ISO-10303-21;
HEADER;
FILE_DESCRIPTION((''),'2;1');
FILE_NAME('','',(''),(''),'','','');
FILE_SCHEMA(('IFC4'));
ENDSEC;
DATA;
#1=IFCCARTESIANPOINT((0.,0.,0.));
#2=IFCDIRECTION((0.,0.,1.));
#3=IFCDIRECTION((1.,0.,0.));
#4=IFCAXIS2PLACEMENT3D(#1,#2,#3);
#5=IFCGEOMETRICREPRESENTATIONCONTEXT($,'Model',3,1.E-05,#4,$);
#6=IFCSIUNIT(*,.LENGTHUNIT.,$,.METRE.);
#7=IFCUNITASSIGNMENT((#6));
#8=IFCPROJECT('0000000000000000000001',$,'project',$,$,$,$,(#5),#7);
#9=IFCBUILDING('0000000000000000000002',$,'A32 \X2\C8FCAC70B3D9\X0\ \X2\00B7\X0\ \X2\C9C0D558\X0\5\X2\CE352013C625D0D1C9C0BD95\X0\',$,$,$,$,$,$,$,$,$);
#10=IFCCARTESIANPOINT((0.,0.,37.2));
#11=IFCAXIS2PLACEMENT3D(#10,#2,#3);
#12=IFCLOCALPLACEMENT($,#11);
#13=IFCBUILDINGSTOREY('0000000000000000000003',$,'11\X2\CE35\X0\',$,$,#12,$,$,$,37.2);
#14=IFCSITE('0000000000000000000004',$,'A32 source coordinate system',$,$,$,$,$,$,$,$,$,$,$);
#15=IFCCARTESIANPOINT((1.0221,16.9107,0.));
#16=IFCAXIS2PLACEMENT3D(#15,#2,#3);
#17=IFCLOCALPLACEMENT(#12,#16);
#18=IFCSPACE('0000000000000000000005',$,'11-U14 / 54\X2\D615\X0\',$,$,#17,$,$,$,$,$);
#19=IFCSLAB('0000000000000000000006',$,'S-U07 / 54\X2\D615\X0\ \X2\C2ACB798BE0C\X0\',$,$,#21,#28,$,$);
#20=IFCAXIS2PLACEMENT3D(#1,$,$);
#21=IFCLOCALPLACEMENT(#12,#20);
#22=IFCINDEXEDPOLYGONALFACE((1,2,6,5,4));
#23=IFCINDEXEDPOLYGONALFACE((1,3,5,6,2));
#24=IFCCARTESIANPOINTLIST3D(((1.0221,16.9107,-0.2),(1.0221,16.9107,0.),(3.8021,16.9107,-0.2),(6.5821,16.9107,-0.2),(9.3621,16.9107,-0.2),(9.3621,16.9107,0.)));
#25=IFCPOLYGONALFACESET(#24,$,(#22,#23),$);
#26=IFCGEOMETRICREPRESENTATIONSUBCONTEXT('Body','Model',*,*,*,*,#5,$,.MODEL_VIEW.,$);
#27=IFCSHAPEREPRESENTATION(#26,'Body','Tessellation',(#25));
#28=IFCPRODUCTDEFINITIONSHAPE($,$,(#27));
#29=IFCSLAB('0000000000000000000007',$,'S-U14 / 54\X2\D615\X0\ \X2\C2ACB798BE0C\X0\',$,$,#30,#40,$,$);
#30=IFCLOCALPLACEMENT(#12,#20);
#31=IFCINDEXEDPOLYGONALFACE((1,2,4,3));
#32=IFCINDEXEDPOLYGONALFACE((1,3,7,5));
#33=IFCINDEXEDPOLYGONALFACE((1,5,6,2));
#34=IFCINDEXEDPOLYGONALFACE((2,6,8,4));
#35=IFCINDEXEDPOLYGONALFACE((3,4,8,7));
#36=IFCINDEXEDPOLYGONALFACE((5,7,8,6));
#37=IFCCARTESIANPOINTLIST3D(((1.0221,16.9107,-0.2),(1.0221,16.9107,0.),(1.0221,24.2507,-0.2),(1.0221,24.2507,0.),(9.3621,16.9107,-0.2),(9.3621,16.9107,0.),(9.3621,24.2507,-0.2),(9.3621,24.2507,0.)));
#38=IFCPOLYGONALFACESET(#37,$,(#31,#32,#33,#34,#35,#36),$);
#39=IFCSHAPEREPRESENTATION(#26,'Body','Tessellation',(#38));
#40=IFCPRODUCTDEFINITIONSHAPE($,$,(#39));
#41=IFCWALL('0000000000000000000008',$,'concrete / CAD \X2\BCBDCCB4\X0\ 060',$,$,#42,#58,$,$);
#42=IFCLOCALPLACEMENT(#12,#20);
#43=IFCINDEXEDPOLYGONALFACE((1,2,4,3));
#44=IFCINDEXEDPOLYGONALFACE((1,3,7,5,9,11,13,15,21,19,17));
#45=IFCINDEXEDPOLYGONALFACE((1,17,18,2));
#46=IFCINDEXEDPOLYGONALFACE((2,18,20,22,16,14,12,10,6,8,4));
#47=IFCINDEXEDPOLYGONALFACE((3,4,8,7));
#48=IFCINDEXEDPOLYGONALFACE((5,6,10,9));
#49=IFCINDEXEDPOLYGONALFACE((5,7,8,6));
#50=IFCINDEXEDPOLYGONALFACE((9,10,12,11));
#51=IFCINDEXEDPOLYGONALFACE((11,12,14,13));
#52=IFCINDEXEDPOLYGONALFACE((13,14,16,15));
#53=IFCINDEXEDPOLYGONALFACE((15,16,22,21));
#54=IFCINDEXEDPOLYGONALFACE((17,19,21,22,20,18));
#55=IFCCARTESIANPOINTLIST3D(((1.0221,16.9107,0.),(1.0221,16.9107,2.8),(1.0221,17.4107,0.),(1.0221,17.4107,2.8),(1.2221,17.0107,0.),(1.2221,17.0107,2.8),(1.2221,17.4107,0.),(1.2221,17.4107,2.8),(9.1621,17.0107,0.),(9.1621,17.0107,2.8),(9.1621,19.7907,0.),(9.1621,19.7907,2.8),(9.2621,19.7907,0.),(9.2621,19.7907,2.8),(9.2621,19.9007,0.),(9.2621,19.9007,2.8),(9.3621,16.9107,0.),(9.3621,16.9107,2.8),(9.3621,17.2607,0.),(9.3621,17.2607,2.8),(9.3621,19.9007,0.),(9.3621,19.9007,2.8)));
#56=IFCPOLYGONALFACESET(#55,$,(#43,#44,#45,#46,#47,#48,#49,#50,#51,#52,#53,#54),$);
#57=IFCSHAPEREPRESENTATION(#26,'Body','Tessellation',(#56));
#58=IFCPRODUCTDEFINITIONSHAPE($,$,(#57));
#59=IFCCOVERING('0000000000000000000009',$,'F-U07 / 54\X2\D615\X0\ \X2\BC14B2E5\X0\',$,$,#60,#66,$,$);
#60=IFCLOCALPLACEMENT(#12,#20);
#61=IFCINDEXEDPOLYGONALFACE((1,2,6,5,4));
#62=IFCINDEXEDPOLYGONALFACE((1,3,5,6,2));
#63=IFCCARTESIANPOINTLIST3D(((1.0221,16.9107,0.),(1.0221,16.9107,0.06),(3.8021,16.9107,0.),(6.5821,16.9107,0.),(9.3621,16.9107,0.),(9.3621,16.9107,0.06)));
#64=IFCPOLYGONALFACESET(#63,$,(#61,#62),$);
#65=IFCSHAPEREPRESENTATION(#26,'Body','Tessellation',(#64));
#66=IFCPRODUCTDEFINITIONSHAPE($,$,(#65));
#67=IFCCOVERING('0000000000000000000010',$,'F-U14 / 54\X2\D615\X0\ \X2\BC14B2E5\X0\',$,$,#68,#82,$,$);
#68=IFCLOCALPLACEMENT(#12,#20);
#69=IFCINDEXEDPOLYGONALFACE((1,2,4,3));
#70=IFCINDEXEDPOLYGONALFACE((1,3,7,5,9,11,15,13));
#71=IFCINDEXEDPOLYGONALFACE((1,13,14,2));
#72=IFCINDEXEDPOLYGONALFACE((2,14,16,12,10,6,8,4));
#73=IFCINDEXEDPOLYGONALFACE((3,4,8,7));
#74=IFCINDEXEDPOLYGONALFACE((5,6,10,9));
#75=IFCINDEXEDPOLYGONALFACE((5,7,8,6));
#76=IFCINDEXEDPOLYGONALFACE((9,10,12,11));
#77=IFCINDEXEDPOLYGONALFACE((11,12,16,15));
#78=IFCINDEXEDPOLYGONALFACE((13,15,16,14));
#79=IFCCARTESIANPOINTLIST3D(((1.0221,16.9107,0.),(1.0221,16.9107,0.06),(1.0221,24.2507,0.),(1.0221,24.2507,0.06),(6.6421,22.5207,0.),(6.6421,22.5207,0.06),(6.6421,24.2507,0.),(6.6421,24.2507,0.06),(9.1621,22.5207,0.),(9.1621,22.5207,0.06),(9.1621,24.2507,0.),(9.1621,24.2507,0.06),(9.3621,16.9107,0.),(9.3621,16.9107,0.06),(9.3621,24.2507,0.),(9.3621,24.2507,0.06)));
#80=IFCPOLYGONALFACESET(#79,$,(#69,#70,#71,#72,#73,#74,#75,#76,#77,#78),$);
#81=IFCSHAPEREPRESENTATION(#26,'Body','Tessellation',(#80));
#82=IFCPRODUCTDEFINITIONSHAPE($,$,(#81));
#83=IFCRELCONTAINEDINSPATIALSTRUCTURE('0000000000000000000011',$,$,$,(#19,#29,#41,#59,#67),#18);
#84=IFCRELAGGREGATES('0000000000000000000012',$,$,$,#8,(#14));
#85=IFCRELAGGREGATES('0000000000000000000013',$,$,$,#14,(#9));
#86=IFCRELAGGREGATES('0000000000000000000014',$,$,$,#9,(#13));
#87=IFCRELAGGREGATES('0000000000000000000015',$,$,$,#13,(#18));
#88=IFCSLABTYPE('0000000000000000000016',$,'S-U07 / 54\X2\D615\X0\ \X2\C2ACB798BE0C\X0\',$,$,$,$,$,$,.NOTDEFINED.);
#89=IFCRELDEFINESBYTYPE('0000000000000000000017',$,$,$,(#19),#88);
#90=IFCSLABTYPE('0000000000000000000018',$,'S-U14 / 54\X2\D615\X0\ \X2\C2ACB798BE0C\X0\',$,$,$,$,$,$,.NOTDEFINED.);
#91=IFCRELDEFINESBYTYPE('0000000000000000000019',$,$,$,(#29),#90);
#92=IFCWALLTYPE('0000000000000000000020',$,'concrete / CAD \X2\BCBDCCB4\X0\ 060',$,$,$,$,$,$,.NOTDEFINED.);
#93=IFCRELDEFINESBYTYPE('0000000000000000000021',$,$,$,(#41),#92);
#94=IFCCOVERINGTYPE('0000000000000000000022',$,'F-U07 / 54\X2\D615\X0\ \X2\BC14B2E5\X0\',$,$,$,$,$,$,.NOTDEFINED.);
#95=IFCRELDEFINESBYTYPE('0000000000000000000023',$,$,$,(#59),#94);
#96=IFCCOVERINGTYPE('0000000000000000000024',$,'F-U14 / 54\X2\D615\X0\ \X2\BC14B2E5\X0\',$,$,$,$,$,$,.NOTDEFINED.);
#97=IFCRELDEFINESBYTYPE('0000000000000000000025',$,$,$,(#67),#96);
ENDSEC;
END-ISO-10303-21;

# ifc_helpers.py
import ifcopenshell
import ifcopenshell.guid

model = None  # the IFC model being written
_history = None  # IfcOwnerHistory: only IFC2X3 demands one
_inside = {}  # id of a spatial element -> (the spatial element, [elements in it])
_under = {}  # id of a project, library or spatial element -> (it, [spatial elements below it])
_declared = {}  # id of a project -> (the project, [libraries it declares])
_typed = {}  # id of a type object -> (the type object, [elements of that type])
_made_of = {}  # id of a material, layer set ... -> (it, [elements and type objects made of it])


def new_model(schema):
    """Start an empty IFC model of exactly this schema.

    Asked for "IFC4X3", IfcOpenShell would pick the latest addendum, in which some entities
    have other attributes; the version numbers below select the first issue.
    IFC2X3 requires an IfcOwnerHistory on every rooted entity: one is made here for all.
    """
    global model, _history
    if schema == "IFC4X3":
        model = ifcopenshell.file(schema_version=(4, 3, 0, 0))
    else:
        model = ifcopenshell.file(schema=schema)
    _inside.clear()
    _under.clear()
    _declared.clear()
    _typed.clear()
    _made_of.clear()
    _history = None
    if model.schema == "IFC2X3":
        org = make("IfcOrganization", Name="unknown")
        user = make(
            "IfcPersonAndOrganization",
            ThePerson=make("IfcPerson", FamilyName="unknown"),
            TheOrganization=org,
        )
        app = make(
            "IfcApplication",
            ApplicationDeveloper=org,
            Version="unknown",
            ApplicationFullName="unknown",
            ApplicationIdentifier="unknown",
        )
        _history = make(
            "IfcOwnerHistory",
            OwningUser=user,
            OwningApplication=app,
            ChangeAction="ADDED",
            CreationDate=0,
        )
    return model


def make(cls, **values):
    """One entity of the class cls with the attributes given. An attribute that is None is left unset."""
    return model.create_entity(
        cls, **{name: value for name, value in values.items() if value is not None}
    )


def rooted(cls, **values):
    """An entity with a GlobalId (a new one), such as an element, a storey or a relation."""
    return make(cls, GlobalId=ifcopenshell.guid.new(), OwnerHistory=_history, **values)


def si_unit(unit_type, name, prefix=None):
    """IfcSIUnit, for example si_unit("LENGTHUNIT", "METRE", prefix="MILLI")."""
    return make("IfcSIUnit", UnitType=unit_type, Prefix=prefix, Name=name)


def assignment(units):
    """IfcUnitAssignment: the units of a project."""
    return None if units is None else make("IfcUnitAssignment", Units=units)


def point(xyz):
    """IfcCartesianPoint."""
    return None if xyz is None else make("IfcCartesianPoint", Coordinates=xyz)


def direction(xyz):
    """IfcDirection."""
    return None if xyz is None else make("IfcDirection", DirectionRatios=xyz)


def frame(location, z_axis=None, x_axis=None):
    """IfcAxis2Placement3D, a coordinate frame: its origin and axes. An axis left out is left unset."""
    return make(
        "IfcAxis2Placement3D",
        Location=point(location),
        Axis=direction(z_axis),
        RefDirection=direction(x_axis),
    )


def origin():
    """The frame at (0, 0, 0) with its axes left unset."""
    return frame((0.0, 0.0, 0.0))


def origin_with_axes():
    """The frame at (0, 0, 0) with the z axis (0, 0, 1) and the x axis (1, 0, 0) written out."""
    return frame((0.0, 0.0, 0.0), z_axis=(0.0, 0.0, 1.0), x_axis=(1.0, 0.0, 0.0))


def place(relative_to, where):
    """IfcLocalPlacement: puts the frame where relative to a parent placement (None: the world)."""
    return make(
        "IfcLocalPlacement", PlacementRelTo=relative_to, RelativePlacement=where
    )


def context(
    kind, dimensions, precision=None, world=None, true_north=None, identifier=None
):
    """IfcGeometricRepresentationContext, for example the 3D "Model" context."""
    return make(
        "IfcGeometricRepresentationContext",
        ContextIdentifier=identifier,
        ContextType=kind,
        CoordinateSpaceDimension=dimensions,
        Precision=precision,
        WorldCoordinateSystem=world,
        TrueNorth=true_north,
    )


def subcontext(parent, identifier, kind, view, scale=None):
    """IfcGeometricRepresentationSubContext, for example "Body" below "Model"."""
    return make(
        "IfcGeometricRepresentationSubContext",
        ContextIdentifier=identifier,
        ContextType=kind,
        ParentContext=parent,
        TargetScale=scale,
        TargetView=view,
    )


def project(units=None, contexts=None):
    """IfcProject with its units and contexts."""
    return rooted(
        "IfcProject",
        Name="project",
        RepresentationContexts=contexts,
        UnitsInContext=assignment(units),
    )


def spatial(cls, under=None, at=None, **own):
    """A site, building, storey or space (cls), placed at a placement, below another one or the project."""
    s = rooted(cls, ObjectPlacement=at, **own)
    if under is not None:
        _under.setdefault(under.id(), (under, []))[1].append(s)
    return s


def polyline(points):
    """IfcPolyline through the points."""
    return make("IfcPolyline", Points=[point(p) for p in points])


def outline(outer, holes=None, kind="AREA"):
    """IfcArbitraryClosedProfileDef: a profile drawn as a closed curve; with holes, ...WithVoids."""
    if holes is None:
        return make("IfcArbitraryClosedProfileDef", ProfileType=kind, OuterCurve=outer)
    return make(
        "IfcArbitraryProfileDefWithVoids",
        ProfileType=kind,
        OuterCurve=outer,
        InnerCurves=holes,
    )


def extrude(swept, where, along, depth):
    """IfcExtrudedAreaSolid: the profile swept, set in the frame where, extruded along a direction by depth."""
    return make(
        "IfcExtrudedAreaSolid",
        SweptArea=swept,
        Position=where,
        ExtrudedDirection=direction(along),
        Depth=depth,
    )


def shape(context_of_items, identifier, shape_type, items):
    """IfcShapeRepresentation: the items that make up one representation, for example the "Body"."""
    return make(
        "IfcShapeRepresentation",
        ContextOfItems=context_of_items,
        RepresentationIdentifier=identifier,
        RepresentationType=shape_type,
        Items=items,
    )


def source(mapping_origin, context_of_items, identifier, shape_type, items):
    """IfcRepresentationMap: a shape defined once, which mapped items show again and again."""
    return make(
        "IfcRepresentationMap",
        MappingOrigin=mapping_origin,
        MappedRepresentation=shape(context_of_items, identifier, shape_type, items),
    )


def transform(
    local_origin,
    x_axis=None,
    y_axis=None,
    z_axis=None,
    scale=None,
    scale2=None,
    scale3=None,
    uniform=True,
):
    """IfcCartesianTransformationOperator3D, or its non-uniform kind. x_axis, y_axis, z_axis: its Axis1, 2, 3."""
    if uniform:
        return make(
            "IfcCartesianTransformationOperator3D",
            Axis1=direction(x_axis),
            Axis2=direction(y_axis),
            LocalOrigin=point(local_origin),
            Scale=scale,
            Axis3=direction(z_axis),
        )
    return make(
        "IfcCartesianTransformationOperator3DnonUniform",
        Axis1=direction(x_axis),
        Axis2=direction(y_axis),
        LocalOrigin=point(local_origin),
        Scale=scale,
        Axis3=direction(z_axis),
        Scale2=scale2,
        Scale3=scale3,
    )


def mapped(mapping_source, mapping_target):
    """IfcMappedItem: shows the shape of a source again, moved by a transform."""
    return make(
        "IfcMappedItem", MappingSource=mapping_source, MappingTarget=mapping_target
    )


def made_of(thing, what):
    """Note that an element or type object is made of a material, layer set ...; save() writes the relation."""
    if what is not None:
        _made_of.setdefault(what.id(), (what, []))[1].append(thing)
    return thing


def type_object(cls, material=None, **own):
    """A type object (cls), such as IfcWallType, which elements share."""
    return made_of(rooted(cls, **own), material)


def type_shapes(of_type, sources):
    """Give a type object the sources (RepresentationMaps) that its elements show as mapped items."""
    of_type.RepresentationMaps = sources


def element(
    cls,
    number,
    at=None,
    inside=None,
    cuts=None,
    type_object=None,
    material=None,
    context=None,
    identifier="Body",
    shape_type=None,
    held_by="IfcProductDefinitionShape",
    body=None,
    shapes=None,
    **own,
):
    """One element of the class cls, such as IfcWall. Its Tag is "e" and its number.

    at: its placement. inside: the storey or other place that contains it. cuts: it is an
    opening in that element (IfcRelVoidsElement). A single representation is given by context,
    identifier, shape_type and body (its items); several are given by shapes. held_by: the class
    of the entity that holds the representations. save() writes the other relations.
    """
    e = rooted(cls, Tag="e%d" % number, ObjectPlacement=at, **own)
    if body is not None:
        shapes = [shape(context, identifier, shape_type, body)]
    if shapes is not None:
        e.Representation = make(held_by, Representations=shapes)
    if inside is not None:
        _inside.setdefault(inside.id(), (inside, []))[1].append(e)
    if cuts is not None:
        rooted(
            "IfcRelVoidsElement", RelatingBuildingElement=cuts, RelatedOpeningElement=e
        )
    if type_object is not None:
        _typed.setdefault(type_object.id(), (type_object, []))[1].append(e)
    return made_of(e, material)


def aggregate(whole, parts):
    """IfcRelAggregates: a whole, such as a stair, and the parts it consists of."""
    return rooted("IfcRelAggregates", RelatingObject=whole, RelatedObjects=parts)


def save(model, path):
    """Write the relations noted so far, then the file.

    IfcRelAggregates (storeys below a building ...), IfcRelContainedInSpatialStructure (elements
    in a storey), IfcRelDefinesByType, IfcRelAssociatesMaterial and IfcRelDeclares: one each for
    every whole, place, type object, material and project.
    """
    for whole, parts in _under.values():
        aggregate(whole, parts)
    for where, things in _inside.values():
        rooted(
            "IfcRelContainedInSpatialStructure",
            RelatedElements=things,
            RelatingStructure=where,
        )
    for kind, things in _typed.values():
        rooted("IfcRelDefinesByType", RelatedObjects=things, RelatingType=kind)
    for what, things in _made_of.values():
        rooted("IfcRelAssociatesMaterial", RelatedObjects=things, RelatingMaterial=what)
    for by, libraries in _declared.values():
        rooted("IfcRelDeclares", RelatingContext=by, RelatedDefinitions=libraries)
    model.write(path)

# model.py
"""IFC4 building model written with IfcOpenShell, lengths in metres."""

from ifc_helpers import new_model, si_unit, frame, origin, origin_with_axes, place, context, subcontext, project, spatial, polyline, outline, extrude, source, transform, mapped, type_object, type_shapes, element, save


model = new_model("IFC4")

# Units and contexts
model_context = context("Model", 3, precision=1e-05, world=origin_with_axes())
body_context = subcontext(model_context, "Body", "Model", "MODEL_VIEW")
ifc_project = project(units=[si_unit("LENGTHUNIT", "METRE")], contexts=[model_context])

# Site, building, storey, space
storey_placement = place(None, frame((0.0, 0.0, 37.2), z_axis=(0.0, 0.0, 1.0), x_axis=(1.0, 0.0, 0.0)))
space_1_placement = place(storey_placement, frame((1.0221, 16.9107, 0.0), z_axis=(0.0, 0.0, 1.0), x_axis=(1.0, 0.0, 0.0)))
site = spatial("IfcSite", under=ifc_project, Name="A32 source coordinate system")
building = spatial("IfcBuilding", under=site, Name="A32 주거동 · 지하5층–옥탑지붕")
storey = spatial("IfcBuildingStorey", under=building, at=storey_placement, Name="11층", Elevation=37.2)
space_1 = spatial("IfcSpace", under=storey, at=space_1_placement, Name="11-U14 / 54형")

# Slabs
slab_type_1 = type_object("IfcSlabType", Name="S-U07 / 54형 슬래브", PredefinedType="NOTDEFINED")
shared_shape_1 = source(origin(), body_context, "Body", "SweptSolid", [
    extrude(outline(polyline([(0.0, 0.0), (0.0, 0.0), (8.34, 0.0), (8.34, 0.0), (0.0, 0.0)])), frame((0.0, 0.0, -0.2)), (0.0, 0.0, 1.0), 0.2),
])
type_shapes(slab_type_1, [shared_shape_1])
slab_1_placement = place(space_1_placement, origin_with_axes())
element("IfcSlab", 1, at=slab_1_placement, inside=space_1, type_object=slab_type_1, Name="S-U07 / 54형 슬래브", context=body_context, shape_type="MappedRepresentation", body=[
    mapped(shared_shape_1, transform((0.0, 0.0, 0.0), scale=1.0)),
])
slab_type_2 = type_object("IfcSlabType", Name="S-U14 / 54형 슬래브", PredefinedType="NOTDEFINED")
shared_shape_2 = source(origin(), body_context, "Body", "SweptSolid", [
    extrude(outline(polyline([(0.0, 0.0), (0.0, 7.34), (8.34, 7.34), (8.34, 0.0), (0.0, 0.0)])), frame((0.0, 0.0, -0.2)), (0.0, 0.0, 1.0), 0.2),
])
type_shapes(slab_type_2, [shared_shape_2])
slab_2_placement = place(space_1_placement, origin_with_axes())
element("IfcSlab", 2, at=slab_2_placement, inside=space_1, type_object=slab_type_2, Name="S-U14 / 54형 슬래브", context=body_context, shape_type="MappedRepresentation", body=[
    mapped(shared_shape_2, transform((0.0, 0.0, 0.0), scale=1.0)),
])

# Wall
wall_type_1 = type_object("IfcWallType", Name="concrete / CAD 벽체 060", PredefinedType="NOTDEFINED")
shared_shape_3 = source(origin(), body_context, "Body", "SweptSolid", [
    extrude(outline(polyline([(0.2, 0.5), (0.2, 0.1), (8.14, 0.1), (8.14, 2.88), (8.24, 2.88), (8.24, 2.99), (8.34, 2.99), (8.34, 0.35), (8.34, 0.35), (8.34, 0.0), (0.0, 0.0), (0.0, 0.5), (0.2, 0.5)])), origin(), (0.0, 0.0, 1.0), 2.8),
])
type_shapes(wall_type_1, [shared_shape_3])
wall_1_placement = place(space_1_placement, origin_with_axes())
element("IfcWall", 3, at=wall_1_placement, inside=space_1, type_object=wall_type_1, Name="concrete / CAD 벽체 060", context=body_context, shape_type="MappedRepresentation", body=[
    mapped(shared_shape_3, transform((0.0, 0.0, 0.0), scale=1.0)),
])

# Coverings
covering_type_1 = type_object("IfcCoveringType", Name="F-U07 / 54형 바닥", PredefinedType="NOTDEFINED")
shared_shape_4 = source(origin(), body_context, "Body", "SweptSolid", [
    extrude(outline(polyline([(0.0, 0.0), (0.0, 0.0), (8.34, 0.0), (8.34, 0.0), (0.0, 0.0)])), origin(), (0.0, 0.0, 1.0), 0.06),
])
type_shapes(covering_type_1, [shared_shape_4])
covering_1_placement = place(space_1_placement, origin_with_axes())
element("IfcCovering", 4, at=covering_1_placement, inside=space_1, type_object=covering_type_1, Name="F-U07 / 54형 바닥", context=body_context, shape_type="MappedRepresentation", body=[
    mapped(shared_shape_4, transform((0.0, 0.0, 0.0), scale=1.0)),
])
covering_type_2 = type_object("IfcCoveringType", Name="F-U14 / 54형 바닥", PredefinedType="NOTDEFINED")
shared_shape_5 = source(origin(), body_context, "Body", "SweptSolid", [
    extrude(outline(polyline([(8.14, 7.34), (8.34, 7.34), (8.34, 0.0), (0.0, 0.0), (0.0, 7.34), (5.62, 7.34), (5.62, 5.61), (8.14, 5.61), (8.14, 7.34)])), origin(), (0.0, 0.0, 1.0), 0.06),
])
type_shapes(covering_type_2, [shared_shape_5])
covering_2_placement = place(space_1_placement, origin_with_axes())
element("IfcCovering", 5, at=covering_2_placement, inside=space_1, type_object=covering_type_2, Name="F-U14 / 54형 바닥", context=body_context, shape_type="MappedRepresentation", body=[
    mapped(shared_shape_5, transform((0.0, 0.0, 0.0), scale=1.0)),
])

save(model, "model.ifc")
